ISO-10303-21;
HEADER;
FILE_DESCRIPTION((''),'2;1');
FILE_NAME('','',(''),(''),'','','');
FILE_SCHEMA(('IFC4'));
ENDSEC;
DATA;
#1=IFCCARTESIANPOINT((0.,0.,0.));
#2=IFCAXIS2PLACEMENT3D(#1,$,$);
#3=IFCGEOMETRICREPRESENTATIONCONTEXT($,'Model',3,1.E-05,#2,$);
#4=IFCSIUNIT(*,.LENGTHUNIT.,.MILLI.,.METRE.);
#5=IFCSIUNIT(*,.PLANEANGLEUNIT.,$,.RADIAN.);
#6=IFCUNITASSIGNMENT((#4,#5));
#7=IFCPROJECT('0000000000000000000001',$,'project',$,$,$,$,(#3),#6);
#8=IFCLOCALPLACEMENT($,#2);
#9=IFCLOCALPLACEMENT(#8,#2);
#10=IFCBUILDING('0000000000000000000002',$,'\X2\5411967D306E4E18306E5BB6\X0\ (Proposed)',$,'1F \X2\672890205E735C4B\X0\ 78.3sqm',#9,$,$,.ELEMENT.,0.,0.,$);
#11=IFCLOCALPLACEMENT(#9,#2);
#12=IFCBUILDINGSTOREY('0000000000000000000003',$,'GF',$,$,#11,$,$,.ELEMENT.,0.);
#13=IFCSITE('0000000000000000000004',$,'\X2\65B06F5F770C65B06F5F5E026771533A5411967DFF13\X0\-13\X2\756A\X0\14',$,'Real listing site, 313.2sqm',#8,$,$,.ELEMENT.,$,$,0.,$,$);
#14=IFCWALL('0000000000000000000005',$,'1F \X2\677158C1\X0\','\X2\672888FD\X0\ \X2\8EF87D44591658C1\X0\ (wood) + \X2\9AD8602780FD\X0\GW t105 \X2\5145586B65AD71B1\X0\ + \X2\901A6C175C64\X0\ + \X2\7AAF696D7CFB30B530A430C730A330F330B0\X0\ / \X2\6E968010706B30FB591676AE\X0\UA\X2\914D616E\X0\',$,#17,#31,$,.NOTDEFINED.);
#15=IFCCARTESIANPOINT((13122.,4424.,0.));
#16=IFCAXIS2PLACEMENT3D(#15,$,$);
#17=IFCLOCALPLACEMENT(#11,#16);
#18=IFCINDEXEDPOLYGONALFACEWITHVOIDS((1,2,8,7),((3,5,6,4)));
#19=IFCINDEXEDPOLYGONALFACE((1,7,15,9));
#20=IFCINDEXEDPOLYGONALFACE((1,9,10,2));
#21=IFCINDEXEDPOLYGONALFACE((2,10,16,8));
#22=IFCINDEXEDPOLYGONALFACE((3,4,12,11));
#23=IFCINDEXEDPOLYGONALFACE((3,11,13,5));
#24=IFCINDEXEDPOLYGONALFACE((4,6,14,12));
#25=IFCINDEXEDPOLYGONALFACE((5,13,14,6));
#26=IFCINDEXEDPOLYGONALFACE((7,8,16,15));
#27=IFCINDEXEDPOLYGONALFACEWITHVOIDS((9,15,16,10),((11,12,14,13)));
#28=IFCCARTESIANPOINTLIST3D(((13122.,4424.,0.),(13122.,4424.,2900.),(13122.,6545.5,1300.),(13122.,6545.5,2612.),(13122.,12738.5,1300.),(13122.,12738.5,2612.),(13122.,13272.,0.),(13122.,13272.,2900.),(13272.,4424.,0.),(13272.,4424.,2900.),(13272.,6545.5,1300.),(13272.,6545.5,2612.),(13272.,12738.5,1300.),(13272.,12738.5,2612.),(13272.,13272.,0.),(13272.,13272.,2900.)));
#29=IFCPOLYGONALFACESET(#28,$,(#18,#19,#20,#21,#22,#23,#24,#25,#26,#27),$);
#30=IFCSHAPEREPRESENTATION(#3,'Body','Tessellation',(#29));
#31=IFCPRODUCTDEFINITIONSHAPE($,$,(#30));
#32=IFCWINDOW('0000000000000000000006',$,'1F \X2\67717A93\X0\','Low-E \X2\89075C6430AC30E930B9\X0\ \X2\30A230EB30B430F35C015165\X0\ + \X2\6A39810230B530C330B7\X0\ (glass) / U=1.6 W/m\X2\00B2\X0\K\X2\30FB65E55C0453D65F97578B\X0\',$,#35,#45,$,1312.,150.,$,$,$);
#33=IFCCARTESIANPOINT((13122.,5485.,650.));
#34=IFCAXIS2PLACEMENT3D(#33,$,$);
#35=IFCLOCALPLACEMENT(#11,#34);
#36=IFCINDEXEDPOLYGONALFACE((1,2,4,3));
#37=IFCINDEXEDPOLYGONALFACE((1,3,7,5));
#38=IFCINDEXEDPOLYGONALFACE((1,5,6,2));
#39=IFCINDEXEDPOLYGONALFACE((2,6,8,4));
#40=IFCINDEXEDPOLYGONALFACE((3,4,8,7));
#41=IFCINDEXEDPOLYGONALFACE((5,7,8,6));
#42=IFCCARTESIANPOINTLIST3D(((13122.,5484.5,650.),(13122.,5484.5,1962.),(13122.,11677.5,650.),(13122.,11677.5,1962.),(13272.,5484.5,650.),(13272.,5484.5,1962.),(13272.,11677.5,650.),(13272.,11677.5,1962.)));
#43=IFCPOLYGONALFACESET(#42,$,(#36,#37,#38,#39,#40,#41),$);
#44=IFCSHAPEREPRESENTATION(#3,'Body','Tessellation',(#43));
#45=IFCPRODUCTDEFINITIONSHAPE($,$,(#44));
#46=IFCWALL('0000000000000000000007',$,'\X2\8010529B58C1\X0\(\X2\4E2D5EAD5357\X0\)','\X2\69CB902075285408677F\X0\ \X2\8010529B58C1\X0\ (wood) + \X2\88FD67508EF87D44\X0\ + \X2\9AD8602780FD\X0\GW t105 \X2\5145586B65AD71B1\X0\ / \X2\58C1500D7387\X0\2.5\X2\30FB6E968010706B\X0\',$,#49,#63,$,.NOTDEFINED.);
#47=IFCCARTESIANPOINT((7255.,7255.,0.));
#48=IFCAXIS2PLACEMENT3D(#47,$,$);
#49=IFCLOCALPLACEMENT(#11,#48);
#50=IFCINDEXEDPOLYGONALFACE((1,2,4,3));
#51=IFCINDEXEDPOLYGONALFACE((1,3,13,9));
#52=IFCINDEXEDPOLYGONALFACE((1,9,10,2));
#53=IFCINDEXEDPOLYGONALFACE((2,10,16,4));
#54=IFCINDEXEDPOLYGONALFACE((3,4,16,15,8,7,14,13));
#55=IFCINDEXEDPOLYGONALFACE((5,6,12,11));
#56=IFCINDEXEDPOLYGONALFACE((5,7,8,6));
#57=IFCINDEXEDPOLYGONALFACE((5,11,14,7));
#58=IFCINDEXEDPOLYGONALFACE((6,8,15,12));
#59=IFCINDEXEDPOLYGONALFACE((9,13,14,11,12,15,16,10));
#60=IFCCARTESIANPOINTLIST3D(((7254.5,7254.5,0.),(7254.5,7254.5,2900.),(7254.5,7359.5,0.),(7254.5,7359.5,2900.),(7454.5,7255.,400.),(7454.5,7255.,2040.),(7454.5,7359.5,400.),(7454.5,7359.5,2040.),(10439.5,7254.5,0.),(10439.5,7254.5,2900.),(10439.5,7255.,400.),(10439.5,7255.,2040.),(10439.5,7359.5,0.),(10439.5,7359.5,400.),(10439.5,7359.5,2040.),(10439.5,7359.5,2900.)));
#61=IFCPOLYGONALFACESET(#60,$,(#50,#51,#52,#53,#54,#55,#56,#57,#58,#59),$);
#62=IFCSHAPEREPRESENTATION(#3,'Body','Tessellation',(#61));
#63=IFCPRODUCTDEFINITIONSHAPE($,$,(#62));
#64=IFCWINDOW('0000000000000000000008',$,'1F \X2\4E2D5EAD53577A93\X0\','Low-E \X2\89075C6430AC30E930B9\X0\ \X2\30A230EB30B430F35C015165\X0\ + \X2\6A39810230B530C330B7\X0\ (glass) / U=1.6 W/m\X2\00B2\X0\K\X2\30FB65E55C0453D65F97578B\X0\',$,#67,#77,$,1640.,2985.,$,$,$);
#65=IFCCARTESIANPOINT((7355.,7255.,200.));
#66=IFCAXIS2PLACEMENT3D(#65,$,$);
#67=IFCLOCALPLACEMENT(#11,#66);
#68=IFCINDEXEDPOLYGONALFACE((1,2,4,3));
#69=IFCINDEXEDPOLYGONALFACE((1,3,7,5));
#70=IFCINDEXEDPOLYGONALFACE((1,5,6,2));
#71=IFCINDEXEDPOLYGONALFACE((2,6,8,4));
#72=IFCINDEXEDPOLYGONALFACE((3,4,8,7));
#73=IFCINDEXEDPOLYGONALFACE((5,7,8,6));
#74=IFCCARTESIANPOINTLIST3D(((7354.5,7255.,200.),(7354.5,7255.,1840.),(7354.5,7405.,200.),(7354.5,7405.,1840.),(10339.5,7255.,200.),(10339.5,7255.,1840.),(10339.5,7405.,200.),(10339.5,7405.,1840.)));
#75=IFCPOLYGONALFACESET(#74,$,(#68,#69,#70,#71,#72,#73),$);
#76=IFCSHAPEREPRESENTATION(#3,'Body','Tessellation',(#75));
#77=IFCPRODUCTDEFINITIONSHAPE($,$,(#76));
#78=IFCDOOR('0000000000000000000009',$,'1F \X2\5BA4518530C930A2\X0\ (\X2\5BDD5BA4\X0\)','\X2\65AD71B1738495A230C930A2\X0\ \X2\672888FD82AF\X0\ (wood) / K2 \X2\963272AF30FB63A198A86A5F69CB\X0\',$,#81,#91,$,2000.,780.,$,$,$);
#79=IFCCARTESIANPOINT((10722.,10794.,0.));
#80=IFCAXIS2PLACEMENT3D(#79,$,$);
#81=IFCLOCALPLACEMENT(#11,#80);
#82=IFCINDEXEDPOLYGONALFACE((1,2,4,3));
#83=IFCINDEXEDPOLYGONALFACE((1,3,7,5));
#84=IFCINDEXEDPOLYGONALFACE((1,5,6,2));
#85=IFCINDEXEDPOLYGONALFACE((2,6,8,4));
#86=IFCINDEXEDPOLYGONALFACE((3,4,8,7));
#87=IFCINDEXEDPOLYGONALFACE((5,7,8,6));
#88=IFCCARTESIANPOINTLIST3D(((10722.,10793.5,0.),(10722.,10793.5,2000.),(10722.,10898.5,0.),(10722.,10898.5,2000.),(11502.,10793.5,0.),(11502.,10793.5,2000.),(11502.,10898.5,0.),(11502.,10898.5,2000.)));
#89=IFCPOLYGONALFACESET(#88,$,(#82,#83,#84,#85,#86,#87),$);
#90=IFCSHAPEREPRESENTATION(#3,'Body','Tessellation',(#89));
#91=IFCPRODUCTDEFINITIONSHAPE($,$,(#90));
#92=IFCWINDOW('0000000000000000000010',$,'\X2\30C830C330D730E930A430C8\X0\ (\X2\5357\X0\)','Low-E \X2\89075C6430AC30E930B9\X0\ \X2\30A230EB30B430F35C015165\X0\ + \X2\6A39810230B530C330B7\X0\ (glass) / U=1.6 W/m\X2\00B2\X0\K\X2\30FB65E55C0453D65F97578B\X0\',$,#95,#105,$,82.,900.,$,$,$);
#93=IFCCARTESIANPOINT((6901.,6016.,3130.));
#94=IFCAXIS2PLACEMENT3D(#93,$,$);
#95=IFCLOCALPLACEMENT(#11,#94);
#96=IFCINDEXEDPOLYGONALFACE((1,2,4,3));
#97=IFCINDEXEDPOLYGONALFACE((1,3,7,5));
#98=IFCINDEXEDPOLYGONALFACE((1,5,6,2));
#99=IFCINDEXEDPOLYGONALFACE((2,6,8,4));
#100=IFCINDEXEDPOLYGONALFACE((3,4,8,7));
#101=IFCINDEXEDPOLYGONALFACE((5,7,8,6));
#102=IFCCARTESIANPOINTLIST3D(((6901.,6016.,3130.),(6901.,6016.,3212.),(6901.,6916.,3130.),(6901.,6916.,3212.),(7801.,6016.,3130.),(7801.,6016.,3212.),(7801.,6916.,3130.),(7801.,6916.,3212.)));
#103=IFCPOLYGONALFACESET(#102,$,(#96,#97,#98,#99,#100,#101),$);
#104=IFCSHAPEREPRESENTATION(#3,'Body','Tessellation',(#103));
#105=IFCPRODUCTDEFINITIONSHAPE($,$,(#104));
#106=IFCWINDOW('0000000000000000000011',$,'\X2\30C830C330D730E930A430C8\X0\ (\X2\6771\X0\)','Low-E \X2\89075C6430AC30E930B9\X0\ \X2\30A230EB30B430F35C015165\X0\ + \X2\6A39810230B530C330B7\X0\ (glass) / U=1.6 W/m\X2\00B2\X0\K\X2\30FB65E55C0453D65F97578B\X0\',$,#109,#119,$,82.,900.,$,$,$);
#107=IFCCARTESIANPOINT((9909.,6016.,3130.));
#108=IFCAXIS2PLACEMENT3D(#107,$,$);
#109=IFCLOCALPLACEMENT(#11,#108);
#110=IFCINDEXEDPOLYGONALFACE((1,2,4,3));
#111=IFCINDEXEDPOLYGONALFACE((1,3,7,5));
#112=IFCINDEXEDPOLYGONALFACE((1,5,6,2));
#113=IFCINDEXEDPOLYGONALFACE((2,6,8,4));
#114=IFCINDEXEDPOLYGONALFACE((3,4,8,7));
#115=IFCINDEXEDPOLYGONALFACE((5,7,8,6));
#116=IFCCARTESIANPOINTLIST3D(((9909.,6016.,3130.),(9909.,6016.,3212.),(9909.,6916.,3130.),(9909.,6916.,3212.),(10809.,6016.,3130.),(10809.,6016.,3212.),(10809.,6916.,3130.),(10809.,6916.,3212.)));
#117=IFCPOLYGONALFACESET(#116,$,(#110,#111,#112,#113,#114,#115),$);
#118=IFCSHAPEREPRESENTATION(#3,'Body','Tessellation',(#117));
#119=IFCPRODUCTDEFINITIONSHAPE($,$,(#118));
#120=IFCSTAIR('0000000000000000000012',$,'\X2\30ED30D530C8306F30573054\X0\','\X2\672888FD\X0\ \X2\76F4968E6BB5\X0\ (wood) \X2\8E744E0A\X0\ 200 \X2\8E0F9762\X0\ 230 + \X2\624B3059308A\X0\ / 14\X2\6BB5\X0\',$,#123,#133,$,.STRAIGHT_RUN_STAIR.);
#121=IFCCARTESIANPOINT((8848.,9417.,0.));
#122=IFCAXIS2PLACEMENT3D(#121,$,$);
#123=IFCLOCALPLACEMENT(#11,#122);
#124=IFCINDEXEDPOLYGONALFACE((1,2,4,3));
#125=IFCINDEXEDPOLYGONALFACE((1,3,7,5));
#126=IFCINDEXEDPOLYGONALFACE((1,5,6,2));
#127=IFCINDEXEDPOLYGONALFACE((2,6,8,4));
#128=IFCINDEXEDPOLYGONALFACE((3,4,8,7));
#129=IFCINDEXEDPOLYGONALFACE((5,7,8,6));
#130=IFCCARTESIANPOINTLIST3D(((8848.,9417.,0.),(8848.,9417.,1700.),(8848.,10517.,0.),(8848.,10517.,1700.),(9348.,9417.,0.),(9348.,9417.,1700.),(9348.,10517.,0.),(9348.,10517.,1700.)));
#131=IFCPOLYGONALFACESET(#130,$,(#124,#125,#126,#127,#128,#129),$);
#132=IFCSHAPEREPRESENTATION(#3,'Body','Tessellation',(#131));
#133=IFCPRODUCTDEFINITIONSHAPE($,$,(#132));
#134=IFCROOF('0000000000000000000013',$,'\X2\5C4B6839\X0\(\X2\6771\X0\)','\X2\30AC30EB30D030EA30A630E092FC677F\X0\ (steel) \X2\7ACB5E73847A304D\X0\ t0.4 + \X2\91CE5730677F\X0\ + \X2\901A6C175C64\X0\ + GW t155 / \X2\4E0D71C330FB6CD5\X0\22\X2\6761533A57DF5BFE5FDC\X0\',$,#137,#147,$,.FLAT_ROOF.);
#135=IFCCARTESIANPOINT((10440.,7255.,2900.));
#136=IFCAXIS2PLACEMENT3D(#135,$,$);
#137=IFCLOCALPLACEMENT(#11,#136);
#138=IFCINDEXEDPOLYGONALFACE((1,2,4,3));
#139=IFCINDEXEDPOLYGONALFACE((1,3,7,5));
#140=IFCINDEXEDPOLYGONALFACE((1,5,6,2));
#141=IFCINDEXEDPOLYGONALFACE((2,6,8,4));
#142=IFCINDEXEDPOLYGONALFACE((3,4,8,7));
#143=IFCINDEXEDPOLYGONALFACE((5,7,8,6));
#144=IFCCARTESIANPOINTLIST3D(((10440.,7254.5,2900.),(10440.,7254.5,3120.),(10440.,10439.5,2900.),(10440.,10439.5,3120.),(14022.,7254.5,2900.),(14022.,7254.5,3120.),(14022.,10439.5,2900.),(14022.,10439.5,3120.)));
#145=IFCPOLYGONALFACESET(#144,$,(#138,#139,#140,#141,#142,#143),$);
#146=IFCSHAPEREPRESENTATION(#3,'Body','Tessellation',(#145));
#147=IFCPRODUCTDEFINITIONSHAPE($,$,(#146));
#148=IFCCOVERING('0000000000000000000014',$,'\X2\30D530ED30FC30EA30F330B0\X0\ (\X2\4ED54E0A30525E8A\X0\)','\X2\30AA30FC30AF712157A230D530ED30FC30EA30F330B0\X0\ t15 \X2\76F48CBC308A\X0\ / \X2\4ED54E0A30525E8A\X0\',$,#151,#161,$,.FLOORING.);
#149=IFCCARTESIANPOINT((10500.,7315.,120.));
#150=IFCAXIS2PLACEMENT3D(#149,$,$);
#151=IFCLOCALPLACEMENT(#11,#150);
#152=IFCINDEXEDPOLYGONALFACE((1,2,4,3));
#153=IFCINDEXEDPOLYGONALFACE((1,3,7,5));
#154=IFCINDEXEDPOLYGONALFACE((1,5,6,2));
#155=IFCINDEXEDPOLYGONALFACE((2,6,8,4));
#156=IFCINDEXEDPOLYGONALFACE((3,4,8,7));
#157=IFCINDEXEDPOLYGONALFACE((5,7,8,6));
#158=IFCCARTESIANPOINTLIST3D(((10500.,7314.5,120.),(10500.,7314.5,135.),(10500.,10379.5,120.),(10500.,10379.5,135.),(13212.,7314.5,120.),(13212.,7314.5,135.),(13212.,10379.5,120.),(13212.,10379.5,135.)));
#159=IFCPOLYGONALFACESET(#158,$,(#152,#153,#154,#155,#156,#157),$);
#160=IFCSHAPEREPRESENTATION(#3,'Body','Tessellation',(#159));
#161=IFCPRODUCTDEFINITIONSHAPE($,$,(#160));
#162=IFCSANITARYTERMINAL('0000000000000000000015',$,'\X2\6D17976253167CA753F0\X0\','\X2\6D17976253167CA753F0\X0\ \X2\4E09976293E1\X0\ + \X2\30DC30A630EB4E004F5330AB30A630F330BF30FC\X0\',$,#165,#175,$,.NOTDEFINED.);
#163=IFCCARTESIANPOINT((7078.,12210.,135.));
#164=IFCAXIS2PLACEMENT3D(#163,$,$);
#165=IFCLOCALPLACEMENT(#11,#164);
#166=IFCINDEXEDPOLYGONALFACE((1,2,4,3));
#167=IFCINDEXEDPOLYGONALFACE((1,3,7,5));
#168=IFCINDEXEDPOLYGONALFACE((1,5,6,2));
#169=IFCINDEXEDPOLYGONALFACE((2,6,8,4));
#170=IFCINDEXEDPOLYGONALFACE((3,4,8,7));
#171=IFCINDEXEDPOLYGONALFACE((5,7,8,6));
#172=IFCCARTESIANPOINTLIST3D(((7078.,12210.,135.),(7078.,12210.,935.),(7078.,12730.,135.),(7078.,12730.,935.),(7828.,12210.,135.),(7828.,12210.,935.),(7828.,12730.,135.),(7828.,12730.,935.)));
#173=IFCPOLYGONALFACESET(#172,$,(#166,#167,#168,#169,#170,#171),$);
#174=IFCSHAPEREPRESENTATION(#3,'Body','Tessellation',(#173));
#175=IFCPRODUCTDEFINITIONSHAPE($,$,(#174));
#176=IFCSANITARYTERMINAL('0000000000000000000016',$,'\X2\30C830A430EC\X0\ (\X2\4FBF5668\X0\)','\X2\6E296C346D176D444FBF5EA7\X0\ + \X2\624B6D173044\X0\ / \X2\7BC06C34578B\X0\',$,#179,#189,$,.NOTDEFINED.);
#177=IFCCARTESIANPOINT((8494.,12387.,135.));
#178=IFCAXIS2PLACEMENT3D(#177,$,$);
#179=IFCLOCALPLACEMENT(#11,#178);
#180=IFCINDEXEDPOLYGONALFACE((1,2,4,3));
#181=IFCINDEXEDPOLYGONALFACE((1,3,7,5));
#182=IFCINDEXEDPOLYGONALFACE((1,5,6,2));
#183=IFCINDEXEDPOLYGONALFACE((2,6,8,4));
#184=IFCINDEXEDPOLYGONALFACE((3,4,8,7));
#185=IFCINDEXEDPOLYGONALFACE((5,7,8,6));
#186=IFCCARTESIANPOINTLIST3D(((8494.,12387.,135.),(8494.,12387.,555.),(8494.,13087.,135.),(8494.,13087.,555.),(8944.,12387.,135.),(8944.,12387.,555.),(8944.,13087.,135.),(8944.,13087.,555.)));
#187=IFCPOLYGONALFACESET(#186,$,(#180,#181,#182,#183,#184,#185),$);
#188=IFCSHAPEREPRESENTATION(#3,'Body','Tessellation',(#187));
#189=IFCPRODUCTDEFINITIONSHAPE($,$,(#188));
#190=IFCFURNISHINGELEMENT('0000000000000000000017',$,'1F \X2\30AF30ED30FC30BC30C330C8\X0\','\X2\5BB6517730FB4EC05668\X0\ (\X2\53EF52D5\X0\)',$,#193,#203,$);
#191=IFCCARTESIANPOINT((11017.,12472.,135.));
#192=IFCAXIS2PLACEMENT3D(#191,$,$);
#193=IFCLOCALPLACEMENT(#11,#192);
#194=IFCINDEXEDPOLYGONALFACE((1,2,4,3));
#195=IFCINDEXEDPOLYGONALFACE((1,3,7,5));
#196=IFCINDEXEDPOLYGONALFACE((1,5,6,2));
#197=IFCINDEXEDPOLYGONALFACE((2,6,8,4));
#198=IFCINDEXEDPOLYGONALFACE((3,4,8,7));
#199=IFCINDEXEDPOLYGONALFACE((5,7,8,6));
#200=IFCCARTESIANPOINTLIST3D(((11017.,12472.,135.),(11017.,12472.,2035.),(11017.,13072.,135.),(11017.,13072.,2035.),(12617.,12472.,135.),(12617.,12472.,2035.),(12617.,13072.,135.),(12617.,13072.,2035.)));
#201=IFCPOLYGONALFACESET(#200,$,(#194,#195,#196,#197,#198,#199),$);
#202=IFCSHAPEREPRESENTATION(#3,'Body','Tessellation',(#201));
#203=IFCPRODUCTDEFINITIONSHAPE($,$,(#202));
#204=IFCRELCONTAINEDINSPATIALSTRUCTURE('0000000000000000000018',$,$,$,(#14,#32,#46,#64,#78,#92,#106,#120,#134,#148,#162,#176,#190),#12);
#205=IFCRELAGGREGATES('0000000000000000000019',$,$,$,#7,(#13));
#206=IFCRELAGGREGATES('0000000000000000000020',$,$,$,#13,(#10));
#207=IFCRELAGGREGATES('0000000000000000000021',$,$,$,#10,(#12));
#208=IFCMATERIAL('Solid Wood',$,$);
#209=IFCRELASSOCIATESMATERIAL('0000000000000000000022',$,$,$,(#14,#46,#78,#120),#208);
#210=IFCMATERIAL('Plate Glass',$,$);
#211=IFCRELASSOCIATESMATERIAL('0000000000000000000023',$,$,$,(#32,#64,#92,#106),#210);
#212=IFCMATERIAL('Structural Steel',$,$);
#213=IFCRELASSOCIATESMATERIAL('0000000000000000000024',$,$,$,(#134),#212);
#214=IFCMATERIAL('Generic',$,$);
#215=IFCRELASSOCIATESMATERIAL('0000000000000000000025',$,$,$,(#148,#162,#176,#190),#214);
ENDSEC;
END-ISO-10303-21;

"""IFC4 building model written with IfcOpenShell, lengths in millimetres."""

from ifc_helpers import new_model, si_unit, frame, frame_2d, origin, place, context, project, spatial, rectangle, extrude, material, element, fill, save


model = new_model("IFC4")

# Units and contexts
model_context = context("Model", 3, precision=1e-05, world=origin())
ifc_project = project(units=[si_unit("LENGTHUNIT", "METRE", prefix="MILLI"), si_unit("PLANEANGLEUNIT", "RADIAN")], contexts=[model_context])

# Site, building, storey
site_placement = place(None, origin())
site = spatial("IfcSite", under=ifc_project, at=site_placement, Name="新潟県新潟市東区向陽３-13番14", ObjectType="Real listing site, 313.2sqm", CompositionType="ELEMENT", RefElevation=0.0)
building_placement = place(site_placement, origin())
building = spatial("IfcBuilding", under=site, at=building_placement, Name="向陽の丘の家 (Proposed)", ObjectType="1F 木造平屋 78.3sqm", CompositionType="ELEMENT", ElevationOfRefHeight=0.0, ElevationOfTerrain=0.0)
storey_placement = place(building_placement, origin())
storey = spatial("IfcBuildingStorey", under=building, at=storey_placement, Name="GF", CompositionType="ELEMENT", Elevation=0.0)

# Shared definitions
ifc_material_1 = material(Name="Solid Wood")

# Walls, openings, windows
wall_1_placement = place(storey_placement, frame((13122.0, 4424.0, 0.0)))
wall_1 = element("IfcWall", 1, at=wall_1_placement, inside=storey, material=ifc_material_1, Name="1F 東壁", Description="木製 軸組外壁 (wood) + 高性能GW t105 充填断熱 + 通気層 + 窯業系サイディング / 準耐火・外皮UA配慮", PredefinedType="NOTDEFINED", context=model_context, shape_type="SweptSolid", body=[
    extrude(rectangle(XDim=150.0, YDim=8848.0, at=frame_2d((75.0, 4424.0))), frame((13122.0, 4424.0, 0.0)), (0.0, 0.0, 1.0), 2900.0),
])
opening_1_placement = place(storey_placement, frame((13122.0, 5485.0, 650.0)))
opening_1 = element("IfcOpeningElement", 2, at=opening_1_placement, cuts=wall_1, PredefinedType="NOTDEFINED", context=model_context, shape_type="SweptSolid", body=[
    extrude(rectangle(XDim=150.0, YDim=6193.0, at=frame_2d((75.0, 3096.0))), frame((13122.0, 5485.0, 650.0)), (0.0, 0.0, 1.0), 1312.0),
])
ifc_material_2 = material(Name="Plate Glass")
window_1_placement = place(storey_placement, frame((13122.0, 5485.0, 650.0)))
window_1 = element("IfcWindow", 3, at=window_1_placement, inside=storey, material=ifc_material_2, Name="1F 東窓", Description="Low-E 複層ガラス アルゴン封入 + 樹脂サッシ (glass) / U=1.6 W/m²K・日射取得型", OverallHeight=1312.0, OverallWidth=150.0, context=model_context, shape_type="SweptSolid", body=[
    extrude(rectangle(XDim=150.0, YDim=6193.0, at=frame_2d((75.0, 3096.0))), frame((13122.0, 5485.0, 650.0)), (0.0, 0.0, 1.0), 1312.0),
])
fill(opening_1, window_1)
wall_2_placement = place(storey_placement, frame((7255.0, 7255.0, 0.0)))
wall_2 = element("IfcWall", 4, at=wall_2_placement, inside=storey, material=ifc_material_1, Name="耐力壁(中庭南)", Description="構造用合板 耐力壁 (wood) + 製材軸組 + 高性能GW t105 充填断熱 / 壁倍率2.5・準耐火", PredefinedType="NOTDEFINED", context=model_context, shape_type="SweptSolid", body=[
    extrude(rectangle(XDim=3185.0, YDim=105.0, at=frame_2d((1592.0, 52.0))), frame((7255.0, 7255.0, 0.0)), (0.0, 0.0, 1.0), 2900.0),
])
opening_2_placement = place(storey_placement, frame((7355.0, 7255.0, 200.0)))
opening_2 = element("IfcOpeningElement", 5, at=opening_2_placement, cuts=wall_2, PredefinedType="NOTDEFINED", context=model_context, shape_type="SweptSolid", body=[
    extrude(rectangle(XDim=2985.0, YDim=150.0, at=frame_2d((1492.0, 75.0))), frame((7355.0, 7255.0, 200.0)), (0.0, 0.0, 1.0), 1640.0),
])
window_2_placement = place(storey_placement, frame((7355.0, 7255.0, 200.0)))
window_2 = element("IfcWindow", 6, at=window_2_placement, inside=storey, material=ifc_material_2, Name="1F 中庭南窓", Description="Low-E 複層ガラス アルゴン封入 + 樹脂サッシ (glass) / U=1.6 W/m²K・日射取得型", OverallHeight=1640.0, OverallWidth=2985.0, context=model_context, shape_type="SweptSolid", body=[
    extrude(rectangle(XDim=2985.0, YDim=150.0, at=frame_2d((1492.0, 75.0))), frame((7355.0, 7255.0, 200.0)), (0.0, 0.0, 1.0), 1640.0),
])
fill(opening_2, window_2)

# Door
door_placement = place(storey_placement, frame((10722.0, 10794.0, 0.0)))
element("IfcDoor", 7, at=door_placement, inside=storey, material=ifc_material_1, Name="1F 室内ドア (寝室)", Description="断熱玄関ドア 木製芯 (wood) / K2 防犯・採風機構", OverallHeight=2000.0, OverallWidth=780.0, context=model_context, shape_type="SweptSolid", body=[
    extrude(rectangle(XDim=780.0, YDim=105.0, at=frame_2d((390.0, 52.0))), frame((10722.0, 10794.0, 0.0)), (0.0, 0.0, 1.0), 2000.0),
])

# Windows
window_3_placement = place(storey_placement, frame((6901.0, 6016.0, 3130.0)))
element("IfcWindow", 8, at=window_3_placement, inside=storey, material=ifc_material_2, Name="トップライト (南)", Description="Low-E 複層ガラス アルゴン封入 + 樹脂サッシ (glass) / U=1.6 W/m²K・日射取得型", OverallHeight=82.0, OverallWidth=900.0, context=model_context, shape_type="SweptSolid", body=[
    extrude(rectangle(XDim=900.0, YDim=900.0, at=frame_2d((450.0, 450.0))), frame((6901.0, 6016.0, 3130.0)), (0.0, 0.0, 1.0), 82.0),
])
window_4_placement = place(storey_placement, frame((9909.0, 6016.0, 3130.0)))
element("IfcWindow", 9, at=window_4_placement, inside=storey, material=ifc_material_2, Name="トップライト (東)", Description="Low-E 複層ガラス アルゴン封入 + 樹脂サッシ (glass) / U=1.6 W/m²K・日射取得型", OverallHeight=82.0, OverallWidth=900.0, context=model_context, shape_type="SweptSolid", body=[
    extrude(rectangle(XDim=900.0, YDim=900.0, at=frame_2d((450.0, 450.0))), frame((9909.0, 6016.0, 3130.0)), (0.0, 0.0, 1.0), 82.0),
])

# Stair
stair_placement = place(storey_placement, frame((8848.0, 9417.0, 0.0)))
element("IfcStair", 10, at=stair_placement, inside=storey, material=ifc_material_1, Name="ロフトはしご", Description="木製 直階段 (wood) 蹴上 200 踏面 230 + 手すり / 14段", PredefinedType="STRAIGHT_RUN_STAIR", context=model_context, shape_type="SweptSolid", body=[
    extrude(rectangle(XDim=500.0, YDim=1100.0, at=frame_2d((250.0, 550.0))), frame((8848.0, 9417.0, 0.0)), (0.0, 0.0, 1.0), 1700.0),
])

# Roof
ifc_material_3 = material(Name="Structural Steel")
roof_placement = place(storey_placement, frame((10440.0, 7255.0, 2900.0)))
element("IfcRoof", 11, at=roof_placement, inside=storey, material=ifc_material_3, Name="屋根(東)", Description="ガルバリウム鋼板 (steel) 立平葺き t0.4 + 野地板 + 通気層 + GW t155 / 不燃・法22条区域対応", PredefinedType="FLAT_ROOF", context=model_context, shape_type="SweptSolid", body=[
    extrude(rectangle(XDim=3582.0, YDim=3185.0, at=frame_2d((1791.0, 1592.0))), frame((10440.0, 7255.0, 2900.0)), (0.0, 0.0, 1.0), 220.0),
])

# Covering
ifc_material_4 = material(Name="Generic")
covering_placement = place(storey_placement, frame((10500.0, 7315.0, 120.0)))
element("IfcCovering", 12, at=covering_placement, inside=storey, material=ifc_material_4, Name="フローリング (仕上げ床)", Description="オーク無垢フローリング t15 直貼り / 仕上げ床", PredefinedType="FLOORING", context=model_context, shape_type="SweptSolid", body=[
    extrude(rectangle(XDim=2712.0, YDim=3065.0, at=frame_2d((1356.0, 1532.0))), frame((10500.0, 7315.0, 120.0)), (0.0, 0.0, 1.0), 15.0),
])

# Sanitary terminals
sanitary_terminal_1_placement = place(storey_placement, frame((7078.0, 12210.0, 135.0)))
element("IfcSanitaryTerminal", 13, at=sanitary_terminal_1_placement, inside=storey, material=ifc_material_4, Name="洗面化粧台", Description="洗面化粧台 三面鏡 + ボウル一体カウンター", PredefinedType="NOTDEFINED", context=model_context, shape_type="SweptSolid", body=[
    extrude(rectangle(XDim=750.0, YDim=520.0, at=frame_2d((375.0, 260.0))), frame((7078.0, 12210.0, 135.0)), (0.0, 0.0, 1.0), 800.0),
])
sanitary_terminal_2_placement = place(storey_placement, frame((8494.0, 12387.0, 135.0)))
element("IfcSanitaryTerminal", 14, at=sanitary_terminal_2_placement, inside=storey, material=ifc_material_4, Name="トイレ (便器)", Description="温水洗浄便座 + 手洗い / 節水型", PredefinedType="NOTDEFINED", context=model_context, shape_type="SweptSolid", body=[
    extrude(rectangle(XDim=450.0, YDim=700.0, at=frame_2d((225.0, 350.0))), frame((8494.0, 12387.0, 135.0)), (0.0, 0.0, 1.0), 420.0),
])

# Furnishing element
furnishing_1_placement = place(storey_placement, frame((11017.0, 12472.0, 135.0)))
element("IfcFurnishingElement", 15, at=furnishing_1_placement, inside=storey, material=ifc_material_4, Name="1F クローゼット", Description="家具・什器 (可動)", context=model_context, shape_type="SweptSolid", body=[
    extrude(rectangle(XDim=1600.0, YDim=600.0, at=frame_2d((800.0, 300.0))), frame((11017.0, 12472.0, 135.0)), (0.0, 0.0, 1.0), 1900.0),
])

save(model, "model.ifc")
